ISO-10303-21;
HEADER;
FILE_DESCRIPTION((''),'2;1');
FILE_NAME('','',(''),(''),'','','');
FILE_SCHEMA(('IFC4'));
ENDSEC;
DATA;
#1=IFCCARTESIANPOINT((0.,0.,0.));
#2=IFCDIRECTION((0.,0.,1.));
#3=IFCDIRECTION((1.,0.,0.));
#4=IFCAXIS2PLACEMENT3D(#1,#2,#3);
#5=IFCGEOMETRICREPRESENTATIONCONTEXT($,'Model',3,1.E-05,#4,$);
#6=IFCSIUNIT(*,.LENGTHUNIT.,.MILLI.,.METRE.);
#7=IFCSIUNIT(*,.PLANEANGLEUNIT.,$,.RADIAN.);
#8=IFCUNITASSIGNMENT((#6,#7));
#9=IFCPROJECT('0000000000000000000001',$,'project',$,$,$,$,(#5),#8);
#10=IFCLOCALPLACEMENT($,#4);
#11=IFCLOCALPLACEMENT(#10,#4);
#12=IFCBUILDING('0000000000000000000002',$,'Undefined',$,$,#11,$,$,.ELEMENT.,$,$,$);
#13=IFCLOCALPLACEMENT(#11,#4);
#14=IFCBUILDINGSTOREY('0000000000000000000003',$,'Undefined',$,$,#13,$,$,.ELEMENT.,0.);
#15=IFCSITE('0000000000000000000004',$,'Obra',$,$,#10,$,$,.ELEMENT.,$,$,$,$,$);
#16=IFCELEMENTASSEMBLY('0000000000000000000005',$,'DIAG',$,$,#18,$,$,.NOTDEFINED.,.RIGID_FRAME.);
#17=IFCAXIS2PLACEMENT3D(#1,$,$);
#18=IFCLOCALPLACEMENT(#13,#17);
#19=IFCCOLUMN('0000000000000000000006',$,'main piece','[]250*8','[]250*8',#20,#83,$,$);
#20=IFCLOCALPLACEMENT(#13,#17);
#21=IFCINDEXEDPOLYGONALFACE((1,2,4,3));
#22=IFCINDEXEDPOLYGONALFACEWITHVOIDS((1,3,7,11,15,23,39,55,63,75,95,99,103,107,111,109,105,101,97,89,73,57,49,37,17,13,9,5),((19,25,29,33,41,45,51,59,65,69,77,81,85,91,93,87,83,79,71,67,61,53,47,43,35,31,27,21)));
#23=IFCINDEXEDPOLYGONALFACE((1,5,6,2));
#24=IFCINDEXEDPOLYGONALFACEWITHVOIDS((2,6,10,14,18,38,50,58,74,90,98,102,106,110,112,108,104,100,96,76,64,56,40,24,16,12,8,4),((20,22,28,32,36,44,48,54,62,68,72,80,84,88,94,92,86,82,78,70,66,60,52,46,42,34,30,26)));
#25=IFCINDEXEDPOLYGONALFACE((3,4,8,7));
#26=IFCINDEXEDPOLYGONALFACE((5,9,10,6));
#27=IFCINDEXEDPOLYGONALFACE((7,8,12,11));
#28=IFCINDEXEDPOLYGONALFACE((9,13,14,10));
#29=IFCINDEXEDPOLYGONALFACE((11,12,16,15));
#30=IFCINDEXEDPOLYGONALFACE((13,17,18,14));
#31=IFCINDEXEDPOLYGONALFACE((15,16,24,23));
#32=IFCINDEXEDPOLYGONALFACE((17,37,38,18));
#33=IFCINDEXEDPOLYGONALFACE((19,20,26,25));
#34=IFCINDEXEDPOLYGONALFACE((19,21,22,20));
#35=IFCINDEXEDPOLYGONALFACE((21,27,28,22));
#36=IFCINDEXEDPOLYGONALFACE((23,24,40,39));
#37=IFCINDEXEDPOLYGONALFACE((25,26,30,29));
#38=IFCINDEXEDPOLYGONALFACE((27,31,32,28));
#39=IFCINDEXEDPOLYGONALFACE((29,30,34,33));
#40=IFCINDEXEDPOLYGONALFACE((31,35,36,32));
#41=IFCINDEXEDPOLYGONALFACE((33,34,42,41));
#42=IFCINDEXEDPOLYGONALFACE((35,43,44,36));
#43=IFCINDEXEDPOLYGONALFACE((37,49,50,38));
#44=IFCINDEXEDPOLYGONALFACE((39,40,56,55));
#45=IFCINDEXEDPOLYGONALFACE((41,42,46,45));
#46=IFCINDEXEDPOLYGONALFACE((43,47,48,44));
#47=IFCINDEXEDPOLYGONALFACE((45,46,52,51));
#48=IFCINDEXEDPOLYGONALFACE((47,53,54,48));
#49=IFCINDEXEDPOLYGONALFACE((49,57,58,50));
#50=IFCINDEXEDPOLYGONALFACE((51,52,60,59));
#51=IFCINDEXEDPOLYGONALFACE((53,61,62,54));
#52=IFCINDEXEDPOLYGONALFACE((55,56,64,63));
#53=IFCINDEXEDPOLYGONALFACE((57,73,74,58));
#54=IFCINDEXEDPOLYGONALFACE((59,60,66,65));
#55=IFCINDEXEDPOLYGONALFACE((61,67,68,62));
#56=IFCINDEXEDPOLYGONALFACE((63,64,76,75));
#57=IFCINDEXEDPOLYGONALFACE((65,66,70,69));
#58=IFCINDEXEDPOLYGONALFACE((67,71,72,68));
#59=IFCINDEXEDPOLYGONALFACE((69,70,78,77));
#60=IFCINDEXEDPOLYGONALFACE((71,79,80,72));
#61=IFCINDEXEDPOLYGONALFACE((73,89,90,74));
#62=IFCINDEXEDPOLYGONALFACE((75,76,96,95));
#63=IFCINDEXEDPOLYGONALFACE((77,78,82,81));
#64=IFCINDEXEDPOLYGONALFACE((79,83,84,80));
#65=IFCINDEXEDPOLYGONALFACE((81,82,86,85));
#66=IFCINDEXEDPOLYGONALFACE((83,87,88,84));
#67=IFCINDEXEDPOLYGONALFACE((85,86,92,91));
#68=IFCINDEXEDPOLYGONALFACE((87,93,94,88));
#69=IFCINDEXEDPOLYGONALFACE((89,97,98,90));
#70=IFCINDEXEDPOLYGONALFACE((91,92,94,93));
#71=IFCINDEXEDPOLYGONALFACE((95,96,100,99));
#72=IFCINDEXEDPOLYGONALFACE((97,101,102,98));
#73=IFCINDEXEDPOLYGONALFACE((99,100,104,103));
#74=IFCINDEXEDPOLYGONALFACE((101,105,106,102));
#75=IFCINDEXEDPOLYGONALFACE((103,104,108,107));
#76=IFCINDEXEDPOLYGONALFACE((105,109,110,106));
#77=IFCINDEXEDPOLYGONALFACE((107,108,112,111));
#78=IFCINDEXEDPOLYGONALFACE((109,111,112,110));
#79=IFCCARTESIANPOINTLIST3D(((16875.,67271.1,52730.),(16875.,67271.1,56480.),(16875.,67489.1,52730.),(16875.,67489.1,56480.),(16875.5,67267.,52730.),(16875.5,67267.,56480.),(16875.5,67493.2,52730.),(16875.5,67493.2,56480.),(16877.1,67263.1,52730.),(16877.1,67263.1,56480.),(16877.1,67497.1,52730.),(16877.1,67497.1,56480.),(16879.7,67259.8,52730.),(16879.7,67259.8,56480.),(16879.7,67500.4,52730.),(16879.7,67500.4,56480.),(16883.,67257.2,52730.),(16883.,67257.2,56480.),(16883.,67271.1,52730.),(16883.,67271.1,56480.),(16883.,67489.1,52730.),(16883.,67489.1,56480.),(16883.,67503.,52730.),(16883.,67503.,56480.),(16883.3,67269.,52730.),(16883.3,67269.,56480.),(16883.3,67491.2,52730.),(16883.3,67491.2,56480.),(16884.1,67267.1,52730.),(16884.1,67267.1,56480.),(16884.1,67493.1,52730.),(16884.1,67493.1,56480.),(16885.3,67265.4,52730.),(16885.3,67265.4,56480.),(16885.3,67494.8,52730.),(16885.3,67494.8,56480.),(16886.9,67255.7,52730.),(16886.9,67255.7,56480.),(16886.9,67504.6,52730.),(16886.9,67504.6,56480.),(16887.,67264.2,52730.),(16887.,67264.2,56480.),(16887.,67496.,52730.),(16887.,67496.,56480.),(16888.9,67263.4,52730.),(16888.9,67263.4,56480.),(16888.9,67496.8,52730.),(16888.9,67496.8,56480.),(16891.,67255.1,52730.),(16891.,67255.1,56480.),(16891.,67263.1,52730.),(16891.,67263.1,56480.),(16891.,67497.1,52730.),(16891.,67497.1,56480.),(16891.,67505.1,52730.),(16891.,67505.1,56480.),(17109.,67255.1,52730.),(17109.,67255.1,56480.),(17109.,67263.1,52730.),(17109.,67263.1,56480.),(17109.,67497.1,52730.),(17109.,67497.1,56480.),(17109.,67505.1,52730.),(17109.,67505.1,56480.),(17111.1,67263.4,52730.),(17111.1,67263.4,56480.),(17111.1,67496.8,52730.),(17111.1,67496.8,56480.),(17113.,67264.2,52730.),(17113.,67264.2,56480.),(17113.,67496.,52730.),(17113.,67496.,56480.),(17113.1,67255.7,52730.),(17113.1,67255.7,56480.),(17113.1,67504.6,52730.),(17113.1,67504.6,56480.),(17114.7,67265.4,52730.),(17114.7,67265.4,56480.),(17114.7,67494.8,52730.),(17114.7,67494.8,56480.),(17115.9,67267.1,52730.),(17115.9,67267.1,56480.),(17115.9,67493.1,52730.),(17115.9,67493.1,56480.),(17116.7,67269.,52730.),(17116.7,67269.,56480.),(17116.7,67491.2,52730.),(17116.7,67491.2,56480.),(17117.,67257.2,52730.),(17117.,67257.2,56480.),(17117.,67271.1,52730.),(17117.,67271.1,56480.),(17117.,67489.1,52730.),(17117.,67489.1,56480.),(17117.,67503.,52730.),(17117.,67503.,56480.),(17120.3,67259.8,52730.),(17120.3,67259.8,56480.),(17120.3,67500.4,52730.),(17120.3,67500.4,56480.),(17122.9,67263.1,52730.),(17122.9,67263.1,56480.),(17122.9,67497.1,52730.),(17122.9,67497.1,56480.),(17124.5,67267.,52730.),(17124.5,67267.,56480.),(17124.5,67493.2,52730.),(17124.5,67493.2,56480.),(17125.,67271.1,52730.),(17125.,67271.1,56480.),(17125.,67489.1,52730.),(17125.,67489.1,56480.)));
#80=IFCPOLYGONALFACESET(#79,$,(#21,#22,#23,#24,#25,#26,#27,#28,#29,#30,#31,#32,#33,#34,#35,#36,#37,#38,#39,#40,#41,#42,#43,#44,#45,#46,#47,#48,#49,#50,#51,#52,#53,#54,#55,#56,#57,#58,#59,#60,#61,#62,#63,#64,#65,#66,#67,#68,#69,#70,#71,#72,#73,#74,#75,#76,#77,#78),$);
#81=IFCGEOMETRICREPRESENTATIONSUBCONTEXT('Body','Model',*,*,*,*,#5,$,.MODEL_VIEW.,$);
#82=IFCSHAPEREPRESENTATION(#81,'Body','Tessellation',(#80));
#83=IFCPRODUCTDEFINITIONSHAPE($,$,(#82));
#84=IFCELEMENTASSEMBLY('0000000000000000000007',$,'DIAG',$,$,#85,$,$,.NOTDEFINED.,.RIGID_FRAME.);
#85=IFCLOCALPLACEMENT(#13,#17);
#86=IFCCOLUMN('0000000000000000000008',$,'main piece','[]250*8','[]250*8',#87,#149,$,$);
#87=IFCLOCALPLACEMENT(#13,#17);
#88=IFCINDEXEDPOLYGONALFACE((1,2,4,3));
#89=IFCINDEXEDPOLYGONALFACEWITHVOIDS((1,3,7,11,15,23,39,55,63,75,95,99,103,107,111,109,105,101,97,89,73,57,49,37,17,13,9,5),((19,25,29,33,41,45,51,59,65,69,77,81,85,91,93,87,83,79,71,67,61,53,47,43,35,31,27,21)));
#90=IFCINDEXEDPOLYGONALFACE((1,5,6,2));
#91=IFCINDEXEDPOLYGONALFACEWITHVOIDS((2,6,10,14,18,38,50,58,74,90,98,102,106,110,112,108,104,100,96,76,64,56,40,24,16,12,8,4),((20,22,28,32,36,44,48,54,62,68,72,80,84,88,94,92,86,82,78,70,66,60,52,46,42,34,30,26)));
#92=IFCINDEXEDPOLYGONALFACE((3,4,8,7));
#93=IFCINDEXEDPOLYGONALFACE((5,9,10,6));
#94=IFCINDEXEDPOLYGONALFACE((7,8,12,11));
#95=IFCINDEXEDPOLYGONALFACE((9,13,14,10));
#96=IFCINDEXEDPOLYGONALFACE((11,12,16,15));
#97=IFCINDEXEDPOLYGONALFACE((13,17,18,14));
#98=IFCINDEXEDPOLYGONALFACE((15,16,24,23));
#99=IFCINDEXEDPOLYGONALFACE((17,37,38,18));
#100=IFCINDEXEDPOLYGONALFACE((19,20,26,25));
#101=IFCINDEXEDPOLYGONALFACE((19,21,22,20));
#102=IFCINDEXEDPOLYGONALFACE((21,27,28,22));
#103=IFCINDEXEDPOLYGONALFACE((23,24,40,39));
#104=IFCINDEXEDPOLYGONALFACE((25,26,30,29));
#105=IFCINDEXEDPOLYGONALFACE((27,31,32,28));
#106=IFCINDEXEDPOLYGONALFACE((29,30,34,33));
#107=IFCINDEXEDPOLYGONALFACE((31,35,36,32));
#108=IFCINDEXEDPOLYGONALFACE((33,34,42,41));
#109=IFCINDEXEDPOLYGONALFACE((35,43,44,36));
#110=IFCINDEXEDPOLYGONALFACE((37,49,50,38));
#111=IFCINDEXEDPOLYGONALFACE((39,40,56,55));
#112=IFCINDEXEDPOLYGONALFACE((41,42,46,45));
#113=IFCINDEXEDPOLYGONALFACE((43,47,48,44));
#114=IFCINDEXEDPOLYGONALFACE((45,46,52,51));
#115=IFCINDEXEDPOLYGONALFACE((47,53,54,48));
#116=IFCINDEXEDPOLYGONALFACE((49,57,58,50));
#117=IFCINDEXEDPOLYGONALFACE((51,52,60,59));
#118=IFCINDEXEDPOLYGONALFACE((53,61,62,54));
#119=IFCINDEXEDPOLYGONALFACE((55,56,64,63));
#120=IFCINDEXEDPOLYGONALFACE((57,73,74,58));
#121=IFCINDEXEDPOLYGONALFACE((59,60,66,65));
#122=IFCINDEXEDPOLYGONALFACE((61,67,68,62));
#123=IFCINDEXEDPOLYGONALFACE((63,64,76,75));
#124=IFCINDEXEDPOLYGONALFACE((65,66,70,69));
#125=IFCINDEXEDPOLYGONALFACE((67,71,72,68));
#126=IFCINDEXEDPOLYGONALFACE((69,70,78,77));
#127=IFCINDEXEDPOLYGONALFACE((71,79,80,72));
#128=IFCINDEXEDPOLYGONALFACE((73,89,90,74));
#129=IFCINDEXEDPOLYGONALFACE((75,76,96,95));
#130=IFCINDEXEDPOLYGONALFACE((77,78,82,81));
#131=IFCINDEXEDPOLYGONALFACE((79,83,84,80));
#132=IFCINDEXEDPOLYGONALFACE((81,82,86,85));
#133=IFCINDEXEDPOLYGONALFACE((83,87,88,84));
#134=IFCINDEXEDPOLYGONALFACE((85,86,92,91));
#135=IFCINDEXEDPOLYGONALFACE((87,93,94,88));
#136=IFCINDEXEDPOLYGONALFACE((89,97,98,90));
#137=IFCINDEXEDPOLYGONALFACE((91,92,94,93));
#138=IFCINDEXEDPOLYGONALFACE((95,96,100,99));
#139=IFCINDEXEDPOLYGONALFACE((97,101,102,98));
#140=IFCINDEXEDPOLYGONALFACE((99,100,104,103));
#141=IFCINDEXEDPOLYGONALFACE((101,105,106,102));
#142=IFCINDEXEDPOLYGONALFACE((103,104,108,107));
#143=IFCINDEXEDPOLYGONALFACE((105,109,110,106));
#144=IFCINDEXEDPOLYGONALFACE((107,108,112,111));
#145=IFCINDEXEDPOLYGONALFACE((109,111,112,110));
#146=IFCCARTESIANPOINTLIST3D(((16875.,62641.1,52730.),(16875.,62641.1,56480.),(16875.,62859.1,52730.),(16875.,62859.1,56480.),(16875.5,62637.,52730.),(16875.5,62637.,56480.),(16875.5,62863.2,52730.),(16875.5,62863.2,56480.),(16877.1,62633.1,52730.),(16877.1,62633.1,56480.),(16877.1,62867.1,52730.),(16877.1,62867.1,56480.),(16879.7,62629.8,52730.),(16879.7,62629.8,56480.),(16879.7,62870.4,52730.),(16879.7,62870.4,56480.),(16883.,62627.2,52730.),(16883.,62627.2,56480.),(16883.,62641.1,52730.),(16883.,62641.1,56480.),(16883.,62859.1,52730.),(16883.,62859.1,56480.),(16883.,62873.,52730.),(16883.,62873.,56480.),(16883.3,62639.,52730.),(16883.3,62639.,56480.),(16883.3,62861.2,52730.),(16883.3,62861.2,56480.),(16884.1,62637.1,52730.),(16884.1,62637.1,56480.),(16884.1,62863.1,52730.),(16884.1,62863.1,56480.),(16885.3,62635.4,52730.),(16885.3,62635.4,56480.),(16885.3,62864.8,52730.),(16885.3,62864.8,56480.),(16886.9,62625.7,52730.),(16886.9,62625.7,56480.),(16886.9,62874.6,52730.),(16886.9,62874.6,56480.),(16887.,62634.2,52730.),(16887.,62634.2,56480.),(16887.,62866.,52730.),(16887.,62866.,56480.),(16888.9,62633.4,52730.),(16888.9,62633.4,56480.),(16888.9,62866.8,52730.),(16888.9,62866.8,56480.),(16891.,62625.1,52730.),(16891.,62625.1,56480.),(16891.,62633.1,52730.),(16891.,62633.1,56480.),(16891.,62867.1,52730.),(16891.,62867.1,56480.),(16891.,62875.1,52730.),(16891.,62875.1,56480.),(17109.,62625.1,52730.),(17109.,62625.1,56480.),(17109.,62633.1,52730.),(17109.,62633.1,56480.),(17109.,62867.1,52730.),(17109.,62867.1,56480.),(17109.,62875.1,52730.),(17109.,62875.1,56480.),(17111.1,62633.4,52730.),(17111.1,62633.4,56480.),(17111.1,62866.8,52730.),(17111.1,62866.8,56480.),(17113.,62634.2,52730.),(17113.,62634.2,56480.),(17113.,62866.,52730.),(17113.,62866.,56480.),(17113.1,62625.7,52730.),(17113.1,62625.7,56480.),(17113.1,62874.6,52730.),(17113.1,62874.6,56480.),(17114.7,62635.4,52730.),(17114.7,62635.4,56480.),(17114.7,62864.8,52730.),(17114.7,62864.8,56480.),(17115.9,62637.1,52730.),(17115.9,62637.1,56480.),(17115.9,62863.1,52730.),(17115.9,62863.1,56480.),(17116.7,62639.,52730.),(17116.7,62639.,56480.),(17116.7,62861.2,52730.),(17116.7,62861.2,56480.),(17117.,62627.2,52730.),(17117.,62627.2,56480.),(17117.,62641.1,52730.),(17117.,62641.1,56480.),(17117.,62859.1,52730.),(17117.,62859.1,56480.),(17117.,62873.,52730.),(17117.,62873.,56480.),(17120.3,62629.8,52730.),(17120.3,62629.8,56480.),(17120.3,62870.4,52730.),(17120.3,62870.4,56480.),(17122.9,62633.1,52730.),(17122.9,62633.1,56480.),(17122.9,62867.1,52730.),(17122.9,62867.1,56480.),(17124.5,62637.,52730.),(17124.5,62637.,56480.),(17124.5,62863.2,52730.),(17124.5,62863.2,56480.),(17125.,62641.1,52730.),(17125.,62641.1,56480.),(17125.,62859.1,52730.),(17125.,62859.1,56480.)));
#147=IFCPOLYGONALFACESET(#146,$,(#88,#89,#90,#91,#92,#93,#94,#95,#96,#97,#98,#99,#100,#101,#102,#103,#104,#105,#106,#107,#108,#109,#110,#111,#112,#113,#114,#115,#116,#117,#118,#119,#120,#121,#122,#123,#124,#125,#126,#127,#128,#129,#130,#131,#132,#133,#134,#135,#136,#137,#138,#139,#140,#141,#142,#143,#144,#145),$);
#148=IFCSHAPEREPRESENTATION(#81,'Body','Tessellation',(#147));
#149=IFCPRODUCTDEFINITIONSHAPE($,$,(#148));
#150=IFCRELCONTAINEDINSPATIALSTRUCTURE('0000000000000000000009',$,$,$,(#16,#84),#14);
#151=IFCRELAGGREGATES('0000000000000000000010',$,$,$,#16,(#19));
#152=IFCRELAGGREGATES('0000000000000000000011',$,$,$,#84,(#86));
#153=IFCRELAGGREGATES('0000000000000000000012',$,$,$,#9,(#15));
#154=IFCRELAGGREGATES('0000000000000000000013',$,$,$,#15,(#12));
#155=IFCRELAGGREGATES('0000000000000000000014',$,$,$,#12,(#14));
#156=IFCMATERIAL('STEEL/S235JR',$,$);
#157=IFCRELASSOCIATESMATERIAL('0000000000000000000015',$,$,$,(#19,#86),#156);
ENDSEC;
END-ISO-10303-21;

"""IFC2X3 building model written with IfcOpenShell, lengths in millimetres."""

from ifc_helpers import new_model, si_unit, frame, origin_with_axes, origin_2d_with_axis, place, context, subcontext, project, spatial, hollow_rectangle, extrude, material, element, aggregate, save


model = new_model("IFC2X3")

# Units and contexts
model_context = context("Model", 3, precision=1e-05, world=origin_with_axes())
body_context = subcontext(model_context, "Body", "Model", "MODEL_VIEW")
ifc_project = project(units=[si_unit("LENGTHUNIT", "METRE", prefix="MILLI"), si_unit("PLANEANGLEUNIT", "RADIAN")], contexts=[model_context])

# Site, building, storey
site_placement = place(None, origin_with_axes())
site = spatial("IfcSite", under=ifc_project, at=site_placement, Name="Obra", CompositionType="ELEMENT")
building_placement = place(site_placement, origin_with_axes())
building = spatial("IfcBuilding", under=site, at=building_placement, Name="Undefined", CompositionType="ELEMENT")
storey_placement = place(building_placement, origin_with_axes())
storey = spatial("IfcBuildingStorey", under=building, at=storey_placement, Name="Undefined", CompositionType="ELEMENT", Elevation=0.0)

# Element assemblies, columns
ifc_material = material(Name="STEEL/S235JR")
assembly_1_placement = place(storey_placement, origin_with_axes())
assembly_1 = element("IfcElementAssembly", 1, at=assembly_1_placement, inside=storey, Name="DIAG", AssemblyPlace="NOTDEFINED", PredefinedType="RIGID_FRAME")
column_1_placement = place(assembly_1_placement, frame((17000.0, 67380.1, 52730.0), z_axis=(0.0, 0.0, 1.0), x_axis=(-1.0, 0.0, 0.0)))
column_1 = element("IfcColumn", 2, at=column_1_placement, material=ifc_material, Name="main piece", Description="[]250*8", ObjectType="[]250*8", context=body_context, shape_type="SweptSolid", body=[
    extrude(hollow_rectangle(XDim=250.0, YDim=250.0, WallThickness=8.0, InnerFilletRadius=8.0, OuterFilletRadius=16.0, at=origin_2d_with_axis()), frame((0.0, 0.0, 3750.0), z_axis=(0.0, 0.0, -1.0), x_axis=(0.0, 1.0, 0.0)), (0.0, 0.0, 1.0), 3750.0),
])
aggregate(assembly_1, [column_1])
assembly_2_placement = place(storey_placement, origin_with_axes())
assembly_2 = element("IfcElementAssembly", 3, at=assembly_2_placement, inside=storey, Name="DIAG", AssemblyPlace="NOTDEFINED", PredefinedType="RIGID_FRAME")
column_2_placement = place(assembly_2_placement, frame((17000.0, 62750.1, 52730.0), z_axis=(0.0, 0.0, 1.0), x_axis=(-1.0, 0.0, 0.0)))
column_2 = element("IfcColumn", 4, at=column_2_placement, material=ifc_material, Name="main piece", Description="[]250*8", ObjectType="[]250*8", context=body_context, shape_type="SweptSolid", body=[
    extrude(hollow_rectangle(XDim=250.0, YDim=250.0, WallThickness=8.0, InnerFilletRadius=8.0, OuterFilletRadius=16.0, at=origin_2d_with_axis()), frame((0.0, 0.0, 3750.0), z_axis=(0.0, 0.0, -1.0), x_axis=(0.0, 1.0, 0.0)), (0.0, 0.0, 1.0), 3750.0),
])
aggregate(assembly_2, [column_2])

save(model, "model.ifc")
